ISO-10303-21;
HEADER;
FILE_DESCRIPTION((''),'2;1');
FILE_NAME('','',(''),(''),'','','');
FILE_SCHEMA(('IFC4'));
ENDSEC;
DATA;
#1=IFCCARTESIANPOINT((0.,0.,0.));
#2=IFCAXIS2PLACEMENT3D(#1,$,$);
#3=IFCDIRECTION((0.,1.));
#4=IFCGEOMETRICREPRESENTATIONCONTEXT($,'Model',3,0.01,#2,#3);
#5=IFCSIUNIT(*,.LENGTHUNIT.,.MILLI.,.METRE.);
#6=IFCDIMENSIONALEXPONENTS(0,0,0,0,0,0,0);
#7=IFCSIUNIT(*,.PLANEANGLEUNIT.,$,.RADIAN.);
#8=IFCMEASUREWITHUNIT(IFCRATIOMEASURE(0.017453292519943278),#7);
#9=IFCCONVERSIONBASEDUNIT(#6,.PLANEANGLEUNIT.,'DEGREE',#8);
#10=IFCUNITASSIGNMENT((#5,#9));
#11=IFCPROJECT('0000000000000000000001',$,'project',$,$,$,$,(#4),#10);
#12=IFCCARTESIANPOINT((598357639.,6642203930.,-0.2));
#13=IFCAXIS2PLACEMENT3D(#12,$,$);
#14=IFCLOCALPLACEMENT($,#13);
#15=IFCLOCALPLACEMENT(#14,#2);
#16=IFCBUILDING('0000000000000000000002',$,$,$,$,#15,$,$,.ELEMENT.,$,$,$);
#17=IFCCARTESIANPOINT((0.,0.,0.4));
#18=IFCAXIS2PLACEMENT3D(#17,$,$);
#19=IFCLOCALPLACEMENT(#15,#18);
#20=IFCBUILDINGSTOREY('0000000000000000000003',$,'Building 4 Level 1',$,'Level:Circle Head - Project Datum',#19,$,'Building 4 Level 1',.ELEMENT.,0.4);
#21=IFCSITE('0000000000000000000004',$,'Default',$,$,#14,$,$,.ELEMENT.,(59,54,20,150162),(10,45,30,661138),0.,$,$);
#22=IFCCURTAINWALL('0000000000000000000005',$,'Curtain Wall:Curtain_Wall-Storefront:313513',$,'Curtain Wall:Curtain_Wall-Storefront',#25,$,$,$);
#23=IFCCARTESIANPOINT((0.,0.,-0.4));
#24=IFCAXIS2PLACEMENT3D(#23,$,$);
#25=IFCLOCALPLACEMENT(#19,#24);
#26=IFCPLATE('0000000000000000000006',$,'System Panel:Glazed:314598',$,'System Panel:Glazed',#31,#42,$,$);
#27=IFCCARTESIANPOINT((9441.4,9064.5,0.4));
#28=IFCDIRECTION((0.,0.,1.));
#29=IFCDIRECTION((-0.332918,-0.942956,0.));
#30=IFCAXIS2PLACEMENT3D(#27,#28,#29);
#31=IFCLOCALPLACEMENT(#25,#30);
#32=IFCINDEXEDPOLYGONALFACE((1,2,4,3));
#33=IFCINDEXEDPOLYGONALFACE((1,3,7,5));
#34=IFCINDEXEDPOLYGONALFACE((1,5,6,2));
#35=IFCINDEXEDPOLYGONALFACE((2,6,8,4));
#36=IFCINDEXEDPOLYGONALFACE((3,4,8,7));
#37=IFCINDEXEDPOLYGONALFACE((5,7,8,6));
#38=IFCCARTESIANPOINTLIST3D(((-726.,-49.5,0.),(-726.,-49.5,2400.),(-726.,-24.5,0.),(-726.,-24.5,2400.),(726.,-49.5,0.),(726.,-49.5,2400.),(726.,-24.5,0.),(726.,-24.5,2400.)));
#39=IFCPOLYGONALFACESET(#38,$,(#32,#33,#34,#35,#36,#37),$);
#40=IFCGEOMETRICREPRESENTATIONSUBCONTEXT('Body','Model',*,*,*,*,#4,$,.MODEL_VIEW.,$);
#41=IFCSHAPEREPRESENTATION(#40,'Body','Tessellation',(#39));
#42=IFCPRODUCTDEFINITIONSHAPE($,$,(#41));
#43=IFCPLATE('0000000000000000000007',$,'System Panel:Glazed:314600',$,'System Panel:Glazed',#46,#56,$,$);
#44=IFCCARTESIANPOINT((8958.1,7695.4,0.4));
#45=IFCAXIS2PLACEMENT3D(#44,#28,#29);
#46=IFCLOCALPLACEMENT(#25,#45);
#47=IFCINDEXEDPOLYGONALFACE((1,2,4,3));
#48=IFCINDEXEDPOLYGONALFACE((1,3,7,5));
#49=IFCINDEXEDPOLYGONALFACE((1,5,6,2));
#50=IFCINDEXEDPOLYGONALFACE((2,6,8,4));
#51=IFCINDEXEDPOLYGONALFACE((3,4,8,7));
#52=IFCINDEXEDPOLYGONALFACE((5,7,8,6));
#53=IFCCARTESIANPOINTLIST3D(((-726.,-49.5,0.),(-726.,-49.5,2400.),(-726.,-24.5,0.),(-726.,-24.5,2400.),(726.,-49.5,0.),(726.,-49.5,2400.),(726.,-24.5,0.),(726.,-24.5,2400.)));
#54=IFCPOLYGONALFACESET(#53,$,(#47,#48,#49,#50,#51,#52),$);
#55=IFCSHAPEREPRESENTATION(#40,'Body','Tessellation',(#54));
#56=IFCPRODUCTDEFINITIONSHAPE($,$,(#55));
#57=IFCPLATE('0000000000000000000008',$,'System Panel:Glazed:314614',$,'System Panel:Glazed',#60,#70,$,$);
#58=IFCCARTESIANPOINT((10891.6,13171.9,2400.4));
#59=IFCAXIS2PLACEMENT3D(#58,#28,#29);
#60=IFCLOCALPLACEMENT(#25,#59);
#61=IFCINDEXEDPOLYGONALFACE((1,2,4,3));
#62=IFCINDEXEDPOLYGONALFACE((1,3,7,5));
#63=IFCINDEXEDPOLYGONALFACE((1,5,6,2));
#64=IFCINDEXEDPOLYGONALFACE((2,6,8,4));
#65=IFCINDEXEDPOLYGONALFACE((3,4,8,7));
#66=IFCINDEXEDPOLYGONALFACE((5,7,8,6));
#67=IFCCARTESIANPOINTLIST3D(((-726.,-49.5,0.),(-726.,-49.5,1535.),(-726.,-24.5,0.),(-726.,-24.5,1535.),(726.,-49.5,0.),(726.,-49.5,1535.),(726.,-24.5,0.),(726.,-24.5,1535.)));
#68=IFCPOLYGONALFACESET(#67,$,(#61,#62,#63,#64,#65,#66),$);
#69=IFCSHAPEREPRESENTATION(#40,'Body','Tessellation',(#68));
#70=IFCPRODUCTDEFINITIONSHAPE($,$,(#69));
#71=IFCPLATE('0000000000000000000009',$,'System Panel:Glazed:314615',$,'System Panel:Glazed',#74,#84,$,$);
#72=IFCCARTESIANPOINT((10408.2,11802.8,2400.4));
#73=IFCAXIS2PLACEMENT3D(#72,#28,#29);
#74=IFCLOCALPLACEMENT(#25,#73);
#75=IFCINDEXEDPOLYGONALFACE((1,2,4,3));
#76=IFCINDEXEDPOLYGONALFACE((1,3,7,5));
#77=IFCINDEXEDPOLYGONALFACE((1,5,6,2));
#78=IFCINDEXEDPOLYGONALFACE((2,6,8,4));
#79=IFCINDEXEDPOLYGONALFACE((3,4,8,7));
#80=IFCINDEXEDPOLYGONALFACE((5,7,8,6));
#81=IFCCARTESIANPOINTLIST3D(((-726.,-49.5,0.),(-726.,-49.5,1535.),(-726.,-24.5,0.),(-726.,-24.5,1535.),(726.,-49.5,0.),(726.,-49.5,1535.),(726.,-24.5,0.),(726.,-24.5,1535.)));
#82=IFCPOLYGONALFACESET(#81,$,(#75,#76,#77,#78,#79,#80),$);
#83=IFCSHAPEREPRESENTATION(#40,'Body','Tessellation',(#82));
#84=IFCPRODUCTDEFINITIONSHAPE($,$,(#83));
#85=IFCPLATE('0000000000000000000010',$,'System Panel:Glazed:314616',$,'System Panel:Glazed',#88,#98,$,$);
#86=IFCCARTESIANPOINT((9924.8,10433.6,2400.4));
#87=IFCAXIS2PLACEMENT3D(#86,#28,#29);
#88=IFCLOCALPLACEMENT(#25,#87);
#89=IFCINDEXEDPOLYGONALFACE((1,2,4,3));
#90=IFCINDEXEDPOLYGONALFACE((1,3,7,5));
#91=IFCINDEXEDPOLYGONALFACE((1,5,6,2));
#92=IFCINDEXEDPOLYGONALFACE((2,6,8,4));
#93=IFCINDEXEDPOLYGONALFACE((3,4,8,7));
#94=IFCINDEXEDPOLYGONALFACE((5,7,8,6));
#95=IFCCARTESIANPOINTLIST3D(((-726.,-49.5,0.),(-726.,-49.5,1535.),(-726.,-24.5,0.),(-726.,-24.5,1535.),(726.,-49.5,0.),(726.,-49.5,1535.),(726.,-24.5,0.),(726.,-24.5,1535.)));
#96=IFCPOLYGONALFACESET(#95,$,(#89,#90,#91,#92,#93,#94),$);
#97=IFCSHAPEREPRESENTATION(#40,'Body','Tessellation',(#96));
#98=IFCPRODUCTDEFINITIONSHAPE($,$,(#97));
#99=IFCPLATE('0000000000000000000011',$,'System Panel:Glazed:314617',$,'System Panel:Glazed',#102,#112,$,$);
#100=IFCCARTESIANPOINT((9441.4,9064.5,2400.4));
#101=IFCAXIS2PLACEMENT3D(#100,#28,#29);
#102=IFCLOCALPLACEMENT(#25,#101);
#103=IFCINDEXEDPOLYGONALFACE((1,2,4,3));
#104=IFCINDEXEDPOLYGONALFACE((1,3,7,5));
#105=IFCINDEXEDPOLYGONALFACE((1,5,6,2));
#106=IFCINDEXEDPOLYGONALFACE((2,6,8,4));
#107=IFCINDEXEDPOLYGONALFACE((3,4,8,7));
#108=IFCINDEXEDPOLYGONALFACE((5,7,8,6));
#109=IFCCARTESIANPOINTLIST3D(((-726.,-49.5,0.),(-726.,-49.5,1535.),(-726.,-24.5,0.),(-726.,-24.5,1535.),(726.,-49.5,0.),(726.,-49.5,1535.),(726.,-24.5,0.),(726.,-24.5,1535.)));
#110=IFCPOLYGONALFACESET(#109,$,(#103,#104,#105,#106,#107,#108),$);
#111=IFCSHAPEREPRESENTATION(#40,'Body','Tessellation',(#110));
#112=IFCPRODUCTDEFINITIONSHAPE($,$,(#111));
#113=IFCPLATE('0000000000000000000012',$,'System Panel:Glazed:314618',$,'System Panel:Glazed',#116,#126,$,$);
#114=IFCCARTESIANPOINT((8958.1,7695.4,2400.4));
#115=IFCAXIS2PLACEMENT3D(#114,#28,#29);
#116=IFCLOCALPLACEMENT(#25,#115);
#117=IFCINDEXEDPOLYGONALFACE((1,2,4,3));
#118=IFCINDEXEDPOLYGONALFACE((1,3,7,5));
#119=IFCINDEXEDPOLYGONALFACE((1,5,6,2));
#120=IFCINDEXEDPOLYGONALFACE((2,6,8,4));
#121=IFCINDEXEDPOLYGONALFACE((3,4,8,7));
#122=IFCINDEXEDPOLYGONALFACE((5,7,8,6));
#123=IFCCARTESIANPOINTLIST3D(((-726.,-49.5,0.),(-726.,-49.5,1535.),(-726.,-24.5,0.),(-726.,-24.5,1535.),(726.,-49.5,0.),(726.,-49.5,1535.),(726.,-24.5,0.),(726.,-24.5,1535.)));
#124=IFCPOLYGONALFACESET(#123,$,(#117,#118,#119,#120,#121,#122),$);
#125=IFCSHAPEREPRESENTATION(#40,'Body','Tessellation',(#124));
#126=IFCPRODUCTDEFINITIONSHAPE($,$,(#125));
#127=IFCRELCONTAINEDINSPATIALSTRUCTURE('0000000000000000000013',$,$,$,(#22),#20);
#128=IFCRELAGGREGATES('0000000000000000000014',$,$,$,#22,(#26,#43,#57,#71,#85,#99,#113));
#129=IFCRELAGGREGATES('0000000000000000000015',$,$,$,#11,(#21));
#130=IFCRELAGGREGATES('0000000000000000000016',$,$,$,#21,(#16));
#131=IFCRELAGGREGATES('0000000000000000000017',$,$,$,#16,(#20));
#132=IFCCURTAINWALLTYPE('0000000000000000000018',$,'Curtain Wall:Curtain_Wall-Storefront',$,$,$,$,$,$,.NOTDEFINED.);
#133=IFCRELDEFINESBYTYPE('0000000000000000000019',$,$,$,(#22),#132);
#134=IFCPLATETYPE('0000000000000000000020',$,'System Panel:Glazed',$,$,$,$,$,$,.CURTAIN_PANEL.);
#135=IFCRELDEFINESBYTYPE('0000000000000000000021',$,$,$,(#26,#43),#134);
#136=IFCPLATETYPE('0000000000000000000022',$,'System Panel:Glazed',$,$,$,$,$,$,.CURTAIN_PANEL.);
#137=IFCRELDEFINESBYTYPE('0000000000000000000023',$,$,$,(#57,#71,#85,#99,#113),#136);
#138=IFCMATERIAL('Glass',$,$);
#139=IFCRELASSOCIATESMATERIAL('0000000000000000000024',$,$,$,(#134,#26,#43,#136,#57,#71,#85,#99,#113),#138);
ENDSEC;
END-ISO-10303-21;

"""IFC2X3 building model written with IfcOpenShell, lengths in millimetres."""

from ifc_helpers import new_model, entity, si_unit, converted_unit, direction, frame, frame_2d, origin, place, context, subcontext, project, spatial, rectangle, extrude, source, transform, mapped, material, type_object, type_shapes, element, aggregate, save


model = new_model("IFC2X3")

# Units and contexts
model_context = context("Model", 3, precision=0.01, world=origin(), true_north=direction((0.0, 1.0)))
body_context = subcontext(model_context, "Body", "Model", "MODEL_VIEW")
ifc_project = project(units=[si_unit("LENGTHUNIT", "METRE", prefix="MILLI"), converted_unit("PLANEANGLEUNIT", "DEGREE", entity("IfcRatioMeasure", 0.017453292519943278), si_unit("PLANEANGLEUNIT", "RADIAN"), dimensions=[0, 0, 0, 0, 0, 0, 0])], contexts=[model_context])

# Site, building, storey
site_placement = place(None, frame((598357639.0, 6642203930.0, -0.2)))
site = spatial("IfcSite", under=ifc_project, at=site_placement, Name="Default", CompositionType="ELEMENT", RefLatitude=(59, 54, 20, 150162), RefLongitude=(10, 45, 30, 661138), RefElevation=0.0)
building_placement = place(site_placement, origin())
building = spatial("IfcBuilding", under=site, at=building_placement, CompositionType="ELEMENT")
storey_placement = place(building_placement, frame((0.0, 0.0, 0.4)))
storey = spatial("IfcBuildingStorey", under=building, at=storey_placement, Name="Building 4 Level 1", ObjectType="Level:Circle Head - Project Datum", LongName="Building 4 Level 1", CompositionType="ELEMENT", Elevation=0.4)

# Curtain wall, plates
curtain_wall_type = type_object("IfcCurtainWallType", Name="Curtain Wall:Curtain_Wall-Storefront", PredefinedType="NOTDEFINED")
ifc_material_1 = material(Name="Glass")
curtain_wall_1_placement = place(storey_placement, frame((0.0, 0.0, -0.4)))
curtain_wall_1 = element("IfcCurtainWall", 1, at=curtain_wall_1_placement, inside=storey, type_object=curtain_wall_type, Name="Curtain Wall:Curtain_Wall-Storefront:313513", ObjectType="Curtain Wall:Curtain_Wall-Storefront")
plate_type_1 = type_object("IfcPlateType", Name="System Panel:Glazed", PredefinedType="CURTAIN_PANEL", material=ifc_material_1)
shared_shape_1 = source(origin(), body_context, "Body", "SweptSolid", [
    extrude(rectangle(XDim=25.0, YDim=1451.9, at=frame_2d((0.0, 0.0), x_axis=(1.0, 0.0))), frame((0.0, -37.0, 0.0), z_axis=(0.0, 0.0, 1.0), x_axis=(0.0, 1.0, 0.0)), (0.0, 0.0, 1.0), 2400.0),
])
type_shapes(plate_type_1, [shared_shape_1])
plate_1_placement = place(curtain_wall_1_placement, frame((9441.4, 9064.5, 0.4), z_axis=(0.0, 0.0, 1.0), x_axis=(-0.332918, -0.942956, 0.0)))
plate_1 = element("IfcPlate", 2, at=plate_1_placement, type_object=plate_type_1, material=ifc_material_1, Name="System Panel:Glazed:314598", ObjectType="System Panel:Glazed", context=body_context, shape_type="MappedRepresentation", body=[
    mapped(shared_shape_1, transform((0.0, 0.0, 0.0), scale=1.0)),
])
plate_2_placement = place(curtain_wall_1_placement, frame((8958.1, 7695.4, 0.4), z_axis=(0.0, 0.0, 1.0), x_axis=(-0.332918, -0.942956, 0.0)))
plate_2 = element("IfcPlate", 3, at=plate_2_placement, type_object=plate_type_1, material=ifc_material_1, Name="System Panel:Glazed:314600", ObjectType="System Panel:Glazed", context=body_context, shape_type="MappedRepresentation", body=[
    mapped(shared_shape_1, transform((0.0, 0.0, 0.0), scale=1.0)),
])
plate_type_2 = type_object("IfcPlateType", Name="System Panel:Glazed", PredefinedType="CURTAIN_PANEL", material=ifc_material_1)
shared_shape_2 = source(origin(), body_context, "Body", "SweptSolid", [
    extrude(rectangle(XDim=25.0, YDim=1451.9, at=frame_2d((0.0, 0.0), x_axis=(1.0, 0.0))), frame((0.0, -37.0, 0.0), z_axis=(0.0, 0.0, 1.0), x_axis=(0.0, 1.0, 0.0)), (0.0, 0.0, 1.0), 1535.0),
])
type_shapes(plate_type_2, [shared_shape_2])
plate_3_placement = place(curtain_wall_1_placement, frame((10891.6, 13171.9, 2400.4), z_axis=(0.0, 0.0, 1.0), x_axis=(-0.332918, -0.942956, 0.0)))
plate_3 = element("IfcPlate", 4, at=plate_3_placement, type_object=plate_type_2, material=ifc_material_1, Name="System Panel:Glazed:314614", ObjectType="System Panel:Glazed", context=body_context, shape_type="MappedRepresentation", body=[
    mapped(shared_shape_2, transform((0.0, 0.0, 0.0), scale=1.0)),
])
plate_4_placement = place(curtain_wall_1_placement, frame((10408.2, 11802.8, 2400.4), z_axis=(0.0, 0.0, 1.0), x_axis=(-0.332918, -0.942956, 0.0)))
plate_4 = element("IfcPlate", 5, at=plate_4_placement, type_object=plate_type_2, material=ifc_material_1, Name="System Panel:Glazed:314615", ObjectType="System Panel:Glazed", context=body_context, shape_type="MappedRepresentation", body=[
    mapped(shared_shape_2, transform((0.0, 0.0, 0.0), scale=1.0)),
])
plate_5_placement = place(curtain_wall_1_placement, frame((9924.8, 10433.6, 2400.4), z_axis=(0.0, 0.0, 1.0), x_axis=(-0.332918, -0.942956, 0.0)))
plate_5 = element("IfcPlate", 6, at=plate_5_placement, type_object=plate_type_2, material=ifc_material_1, Name="System Panel:Glazed:314616", ObjectType="System Panel:Glazed", context=body_context, shape_type="MappedRepresentation", body=[
    mapped(shared_shape_2, transform((0.0, 0.0, 0.0), scale=1.0)),
])
plate_6_placement = place(curtain_wall_1_placement, frame((9441.4, 9064.5, 2400.4), z_axis=(0.0, 0.0, 1.0), x_axis=(-0.332918, -0.942956, 0.0)))
plate_6 = element("IfcPlate", 7, at=plate_6_placement, type_object=plate_type_2, material=ifc_material_1, Name="System Panel:Glazed:314617", ObjectType="System Panel:Glazed", context=body_context, shape_type="MappedRepresentation", body=[
    mapped(shared_shape_2, transform((0.0, 0.0, 0.0), scale=1.0)),
])
plate_7_placement = place(curtain_wall_1_placement, frame((8958.1, 7695.4, 2400.4), z_axis=(0.0, 0.0, 1.0), x_axis=(-0.332918, -0.942956, 0.0)))
plate_7 = element("IfcPlate", 8, at=plate_7_placement, type_object=plate_type_2, material=ifc_material_1, Name="System Panel:Glazed:314618", ObjectType="System Panel:Glazed", context=body_context, shape_type="MappedRepresentation", body=[
    mapped(shared_shape_2, transform((0.0, 0.0, 0.0), scale=1.0)),
])
aggregate(curtain_wall_1, [plate_1, plate_2, plate_3, plate_4, plate_5, plate_6, plate_7])

save(model, "model.ifc")
